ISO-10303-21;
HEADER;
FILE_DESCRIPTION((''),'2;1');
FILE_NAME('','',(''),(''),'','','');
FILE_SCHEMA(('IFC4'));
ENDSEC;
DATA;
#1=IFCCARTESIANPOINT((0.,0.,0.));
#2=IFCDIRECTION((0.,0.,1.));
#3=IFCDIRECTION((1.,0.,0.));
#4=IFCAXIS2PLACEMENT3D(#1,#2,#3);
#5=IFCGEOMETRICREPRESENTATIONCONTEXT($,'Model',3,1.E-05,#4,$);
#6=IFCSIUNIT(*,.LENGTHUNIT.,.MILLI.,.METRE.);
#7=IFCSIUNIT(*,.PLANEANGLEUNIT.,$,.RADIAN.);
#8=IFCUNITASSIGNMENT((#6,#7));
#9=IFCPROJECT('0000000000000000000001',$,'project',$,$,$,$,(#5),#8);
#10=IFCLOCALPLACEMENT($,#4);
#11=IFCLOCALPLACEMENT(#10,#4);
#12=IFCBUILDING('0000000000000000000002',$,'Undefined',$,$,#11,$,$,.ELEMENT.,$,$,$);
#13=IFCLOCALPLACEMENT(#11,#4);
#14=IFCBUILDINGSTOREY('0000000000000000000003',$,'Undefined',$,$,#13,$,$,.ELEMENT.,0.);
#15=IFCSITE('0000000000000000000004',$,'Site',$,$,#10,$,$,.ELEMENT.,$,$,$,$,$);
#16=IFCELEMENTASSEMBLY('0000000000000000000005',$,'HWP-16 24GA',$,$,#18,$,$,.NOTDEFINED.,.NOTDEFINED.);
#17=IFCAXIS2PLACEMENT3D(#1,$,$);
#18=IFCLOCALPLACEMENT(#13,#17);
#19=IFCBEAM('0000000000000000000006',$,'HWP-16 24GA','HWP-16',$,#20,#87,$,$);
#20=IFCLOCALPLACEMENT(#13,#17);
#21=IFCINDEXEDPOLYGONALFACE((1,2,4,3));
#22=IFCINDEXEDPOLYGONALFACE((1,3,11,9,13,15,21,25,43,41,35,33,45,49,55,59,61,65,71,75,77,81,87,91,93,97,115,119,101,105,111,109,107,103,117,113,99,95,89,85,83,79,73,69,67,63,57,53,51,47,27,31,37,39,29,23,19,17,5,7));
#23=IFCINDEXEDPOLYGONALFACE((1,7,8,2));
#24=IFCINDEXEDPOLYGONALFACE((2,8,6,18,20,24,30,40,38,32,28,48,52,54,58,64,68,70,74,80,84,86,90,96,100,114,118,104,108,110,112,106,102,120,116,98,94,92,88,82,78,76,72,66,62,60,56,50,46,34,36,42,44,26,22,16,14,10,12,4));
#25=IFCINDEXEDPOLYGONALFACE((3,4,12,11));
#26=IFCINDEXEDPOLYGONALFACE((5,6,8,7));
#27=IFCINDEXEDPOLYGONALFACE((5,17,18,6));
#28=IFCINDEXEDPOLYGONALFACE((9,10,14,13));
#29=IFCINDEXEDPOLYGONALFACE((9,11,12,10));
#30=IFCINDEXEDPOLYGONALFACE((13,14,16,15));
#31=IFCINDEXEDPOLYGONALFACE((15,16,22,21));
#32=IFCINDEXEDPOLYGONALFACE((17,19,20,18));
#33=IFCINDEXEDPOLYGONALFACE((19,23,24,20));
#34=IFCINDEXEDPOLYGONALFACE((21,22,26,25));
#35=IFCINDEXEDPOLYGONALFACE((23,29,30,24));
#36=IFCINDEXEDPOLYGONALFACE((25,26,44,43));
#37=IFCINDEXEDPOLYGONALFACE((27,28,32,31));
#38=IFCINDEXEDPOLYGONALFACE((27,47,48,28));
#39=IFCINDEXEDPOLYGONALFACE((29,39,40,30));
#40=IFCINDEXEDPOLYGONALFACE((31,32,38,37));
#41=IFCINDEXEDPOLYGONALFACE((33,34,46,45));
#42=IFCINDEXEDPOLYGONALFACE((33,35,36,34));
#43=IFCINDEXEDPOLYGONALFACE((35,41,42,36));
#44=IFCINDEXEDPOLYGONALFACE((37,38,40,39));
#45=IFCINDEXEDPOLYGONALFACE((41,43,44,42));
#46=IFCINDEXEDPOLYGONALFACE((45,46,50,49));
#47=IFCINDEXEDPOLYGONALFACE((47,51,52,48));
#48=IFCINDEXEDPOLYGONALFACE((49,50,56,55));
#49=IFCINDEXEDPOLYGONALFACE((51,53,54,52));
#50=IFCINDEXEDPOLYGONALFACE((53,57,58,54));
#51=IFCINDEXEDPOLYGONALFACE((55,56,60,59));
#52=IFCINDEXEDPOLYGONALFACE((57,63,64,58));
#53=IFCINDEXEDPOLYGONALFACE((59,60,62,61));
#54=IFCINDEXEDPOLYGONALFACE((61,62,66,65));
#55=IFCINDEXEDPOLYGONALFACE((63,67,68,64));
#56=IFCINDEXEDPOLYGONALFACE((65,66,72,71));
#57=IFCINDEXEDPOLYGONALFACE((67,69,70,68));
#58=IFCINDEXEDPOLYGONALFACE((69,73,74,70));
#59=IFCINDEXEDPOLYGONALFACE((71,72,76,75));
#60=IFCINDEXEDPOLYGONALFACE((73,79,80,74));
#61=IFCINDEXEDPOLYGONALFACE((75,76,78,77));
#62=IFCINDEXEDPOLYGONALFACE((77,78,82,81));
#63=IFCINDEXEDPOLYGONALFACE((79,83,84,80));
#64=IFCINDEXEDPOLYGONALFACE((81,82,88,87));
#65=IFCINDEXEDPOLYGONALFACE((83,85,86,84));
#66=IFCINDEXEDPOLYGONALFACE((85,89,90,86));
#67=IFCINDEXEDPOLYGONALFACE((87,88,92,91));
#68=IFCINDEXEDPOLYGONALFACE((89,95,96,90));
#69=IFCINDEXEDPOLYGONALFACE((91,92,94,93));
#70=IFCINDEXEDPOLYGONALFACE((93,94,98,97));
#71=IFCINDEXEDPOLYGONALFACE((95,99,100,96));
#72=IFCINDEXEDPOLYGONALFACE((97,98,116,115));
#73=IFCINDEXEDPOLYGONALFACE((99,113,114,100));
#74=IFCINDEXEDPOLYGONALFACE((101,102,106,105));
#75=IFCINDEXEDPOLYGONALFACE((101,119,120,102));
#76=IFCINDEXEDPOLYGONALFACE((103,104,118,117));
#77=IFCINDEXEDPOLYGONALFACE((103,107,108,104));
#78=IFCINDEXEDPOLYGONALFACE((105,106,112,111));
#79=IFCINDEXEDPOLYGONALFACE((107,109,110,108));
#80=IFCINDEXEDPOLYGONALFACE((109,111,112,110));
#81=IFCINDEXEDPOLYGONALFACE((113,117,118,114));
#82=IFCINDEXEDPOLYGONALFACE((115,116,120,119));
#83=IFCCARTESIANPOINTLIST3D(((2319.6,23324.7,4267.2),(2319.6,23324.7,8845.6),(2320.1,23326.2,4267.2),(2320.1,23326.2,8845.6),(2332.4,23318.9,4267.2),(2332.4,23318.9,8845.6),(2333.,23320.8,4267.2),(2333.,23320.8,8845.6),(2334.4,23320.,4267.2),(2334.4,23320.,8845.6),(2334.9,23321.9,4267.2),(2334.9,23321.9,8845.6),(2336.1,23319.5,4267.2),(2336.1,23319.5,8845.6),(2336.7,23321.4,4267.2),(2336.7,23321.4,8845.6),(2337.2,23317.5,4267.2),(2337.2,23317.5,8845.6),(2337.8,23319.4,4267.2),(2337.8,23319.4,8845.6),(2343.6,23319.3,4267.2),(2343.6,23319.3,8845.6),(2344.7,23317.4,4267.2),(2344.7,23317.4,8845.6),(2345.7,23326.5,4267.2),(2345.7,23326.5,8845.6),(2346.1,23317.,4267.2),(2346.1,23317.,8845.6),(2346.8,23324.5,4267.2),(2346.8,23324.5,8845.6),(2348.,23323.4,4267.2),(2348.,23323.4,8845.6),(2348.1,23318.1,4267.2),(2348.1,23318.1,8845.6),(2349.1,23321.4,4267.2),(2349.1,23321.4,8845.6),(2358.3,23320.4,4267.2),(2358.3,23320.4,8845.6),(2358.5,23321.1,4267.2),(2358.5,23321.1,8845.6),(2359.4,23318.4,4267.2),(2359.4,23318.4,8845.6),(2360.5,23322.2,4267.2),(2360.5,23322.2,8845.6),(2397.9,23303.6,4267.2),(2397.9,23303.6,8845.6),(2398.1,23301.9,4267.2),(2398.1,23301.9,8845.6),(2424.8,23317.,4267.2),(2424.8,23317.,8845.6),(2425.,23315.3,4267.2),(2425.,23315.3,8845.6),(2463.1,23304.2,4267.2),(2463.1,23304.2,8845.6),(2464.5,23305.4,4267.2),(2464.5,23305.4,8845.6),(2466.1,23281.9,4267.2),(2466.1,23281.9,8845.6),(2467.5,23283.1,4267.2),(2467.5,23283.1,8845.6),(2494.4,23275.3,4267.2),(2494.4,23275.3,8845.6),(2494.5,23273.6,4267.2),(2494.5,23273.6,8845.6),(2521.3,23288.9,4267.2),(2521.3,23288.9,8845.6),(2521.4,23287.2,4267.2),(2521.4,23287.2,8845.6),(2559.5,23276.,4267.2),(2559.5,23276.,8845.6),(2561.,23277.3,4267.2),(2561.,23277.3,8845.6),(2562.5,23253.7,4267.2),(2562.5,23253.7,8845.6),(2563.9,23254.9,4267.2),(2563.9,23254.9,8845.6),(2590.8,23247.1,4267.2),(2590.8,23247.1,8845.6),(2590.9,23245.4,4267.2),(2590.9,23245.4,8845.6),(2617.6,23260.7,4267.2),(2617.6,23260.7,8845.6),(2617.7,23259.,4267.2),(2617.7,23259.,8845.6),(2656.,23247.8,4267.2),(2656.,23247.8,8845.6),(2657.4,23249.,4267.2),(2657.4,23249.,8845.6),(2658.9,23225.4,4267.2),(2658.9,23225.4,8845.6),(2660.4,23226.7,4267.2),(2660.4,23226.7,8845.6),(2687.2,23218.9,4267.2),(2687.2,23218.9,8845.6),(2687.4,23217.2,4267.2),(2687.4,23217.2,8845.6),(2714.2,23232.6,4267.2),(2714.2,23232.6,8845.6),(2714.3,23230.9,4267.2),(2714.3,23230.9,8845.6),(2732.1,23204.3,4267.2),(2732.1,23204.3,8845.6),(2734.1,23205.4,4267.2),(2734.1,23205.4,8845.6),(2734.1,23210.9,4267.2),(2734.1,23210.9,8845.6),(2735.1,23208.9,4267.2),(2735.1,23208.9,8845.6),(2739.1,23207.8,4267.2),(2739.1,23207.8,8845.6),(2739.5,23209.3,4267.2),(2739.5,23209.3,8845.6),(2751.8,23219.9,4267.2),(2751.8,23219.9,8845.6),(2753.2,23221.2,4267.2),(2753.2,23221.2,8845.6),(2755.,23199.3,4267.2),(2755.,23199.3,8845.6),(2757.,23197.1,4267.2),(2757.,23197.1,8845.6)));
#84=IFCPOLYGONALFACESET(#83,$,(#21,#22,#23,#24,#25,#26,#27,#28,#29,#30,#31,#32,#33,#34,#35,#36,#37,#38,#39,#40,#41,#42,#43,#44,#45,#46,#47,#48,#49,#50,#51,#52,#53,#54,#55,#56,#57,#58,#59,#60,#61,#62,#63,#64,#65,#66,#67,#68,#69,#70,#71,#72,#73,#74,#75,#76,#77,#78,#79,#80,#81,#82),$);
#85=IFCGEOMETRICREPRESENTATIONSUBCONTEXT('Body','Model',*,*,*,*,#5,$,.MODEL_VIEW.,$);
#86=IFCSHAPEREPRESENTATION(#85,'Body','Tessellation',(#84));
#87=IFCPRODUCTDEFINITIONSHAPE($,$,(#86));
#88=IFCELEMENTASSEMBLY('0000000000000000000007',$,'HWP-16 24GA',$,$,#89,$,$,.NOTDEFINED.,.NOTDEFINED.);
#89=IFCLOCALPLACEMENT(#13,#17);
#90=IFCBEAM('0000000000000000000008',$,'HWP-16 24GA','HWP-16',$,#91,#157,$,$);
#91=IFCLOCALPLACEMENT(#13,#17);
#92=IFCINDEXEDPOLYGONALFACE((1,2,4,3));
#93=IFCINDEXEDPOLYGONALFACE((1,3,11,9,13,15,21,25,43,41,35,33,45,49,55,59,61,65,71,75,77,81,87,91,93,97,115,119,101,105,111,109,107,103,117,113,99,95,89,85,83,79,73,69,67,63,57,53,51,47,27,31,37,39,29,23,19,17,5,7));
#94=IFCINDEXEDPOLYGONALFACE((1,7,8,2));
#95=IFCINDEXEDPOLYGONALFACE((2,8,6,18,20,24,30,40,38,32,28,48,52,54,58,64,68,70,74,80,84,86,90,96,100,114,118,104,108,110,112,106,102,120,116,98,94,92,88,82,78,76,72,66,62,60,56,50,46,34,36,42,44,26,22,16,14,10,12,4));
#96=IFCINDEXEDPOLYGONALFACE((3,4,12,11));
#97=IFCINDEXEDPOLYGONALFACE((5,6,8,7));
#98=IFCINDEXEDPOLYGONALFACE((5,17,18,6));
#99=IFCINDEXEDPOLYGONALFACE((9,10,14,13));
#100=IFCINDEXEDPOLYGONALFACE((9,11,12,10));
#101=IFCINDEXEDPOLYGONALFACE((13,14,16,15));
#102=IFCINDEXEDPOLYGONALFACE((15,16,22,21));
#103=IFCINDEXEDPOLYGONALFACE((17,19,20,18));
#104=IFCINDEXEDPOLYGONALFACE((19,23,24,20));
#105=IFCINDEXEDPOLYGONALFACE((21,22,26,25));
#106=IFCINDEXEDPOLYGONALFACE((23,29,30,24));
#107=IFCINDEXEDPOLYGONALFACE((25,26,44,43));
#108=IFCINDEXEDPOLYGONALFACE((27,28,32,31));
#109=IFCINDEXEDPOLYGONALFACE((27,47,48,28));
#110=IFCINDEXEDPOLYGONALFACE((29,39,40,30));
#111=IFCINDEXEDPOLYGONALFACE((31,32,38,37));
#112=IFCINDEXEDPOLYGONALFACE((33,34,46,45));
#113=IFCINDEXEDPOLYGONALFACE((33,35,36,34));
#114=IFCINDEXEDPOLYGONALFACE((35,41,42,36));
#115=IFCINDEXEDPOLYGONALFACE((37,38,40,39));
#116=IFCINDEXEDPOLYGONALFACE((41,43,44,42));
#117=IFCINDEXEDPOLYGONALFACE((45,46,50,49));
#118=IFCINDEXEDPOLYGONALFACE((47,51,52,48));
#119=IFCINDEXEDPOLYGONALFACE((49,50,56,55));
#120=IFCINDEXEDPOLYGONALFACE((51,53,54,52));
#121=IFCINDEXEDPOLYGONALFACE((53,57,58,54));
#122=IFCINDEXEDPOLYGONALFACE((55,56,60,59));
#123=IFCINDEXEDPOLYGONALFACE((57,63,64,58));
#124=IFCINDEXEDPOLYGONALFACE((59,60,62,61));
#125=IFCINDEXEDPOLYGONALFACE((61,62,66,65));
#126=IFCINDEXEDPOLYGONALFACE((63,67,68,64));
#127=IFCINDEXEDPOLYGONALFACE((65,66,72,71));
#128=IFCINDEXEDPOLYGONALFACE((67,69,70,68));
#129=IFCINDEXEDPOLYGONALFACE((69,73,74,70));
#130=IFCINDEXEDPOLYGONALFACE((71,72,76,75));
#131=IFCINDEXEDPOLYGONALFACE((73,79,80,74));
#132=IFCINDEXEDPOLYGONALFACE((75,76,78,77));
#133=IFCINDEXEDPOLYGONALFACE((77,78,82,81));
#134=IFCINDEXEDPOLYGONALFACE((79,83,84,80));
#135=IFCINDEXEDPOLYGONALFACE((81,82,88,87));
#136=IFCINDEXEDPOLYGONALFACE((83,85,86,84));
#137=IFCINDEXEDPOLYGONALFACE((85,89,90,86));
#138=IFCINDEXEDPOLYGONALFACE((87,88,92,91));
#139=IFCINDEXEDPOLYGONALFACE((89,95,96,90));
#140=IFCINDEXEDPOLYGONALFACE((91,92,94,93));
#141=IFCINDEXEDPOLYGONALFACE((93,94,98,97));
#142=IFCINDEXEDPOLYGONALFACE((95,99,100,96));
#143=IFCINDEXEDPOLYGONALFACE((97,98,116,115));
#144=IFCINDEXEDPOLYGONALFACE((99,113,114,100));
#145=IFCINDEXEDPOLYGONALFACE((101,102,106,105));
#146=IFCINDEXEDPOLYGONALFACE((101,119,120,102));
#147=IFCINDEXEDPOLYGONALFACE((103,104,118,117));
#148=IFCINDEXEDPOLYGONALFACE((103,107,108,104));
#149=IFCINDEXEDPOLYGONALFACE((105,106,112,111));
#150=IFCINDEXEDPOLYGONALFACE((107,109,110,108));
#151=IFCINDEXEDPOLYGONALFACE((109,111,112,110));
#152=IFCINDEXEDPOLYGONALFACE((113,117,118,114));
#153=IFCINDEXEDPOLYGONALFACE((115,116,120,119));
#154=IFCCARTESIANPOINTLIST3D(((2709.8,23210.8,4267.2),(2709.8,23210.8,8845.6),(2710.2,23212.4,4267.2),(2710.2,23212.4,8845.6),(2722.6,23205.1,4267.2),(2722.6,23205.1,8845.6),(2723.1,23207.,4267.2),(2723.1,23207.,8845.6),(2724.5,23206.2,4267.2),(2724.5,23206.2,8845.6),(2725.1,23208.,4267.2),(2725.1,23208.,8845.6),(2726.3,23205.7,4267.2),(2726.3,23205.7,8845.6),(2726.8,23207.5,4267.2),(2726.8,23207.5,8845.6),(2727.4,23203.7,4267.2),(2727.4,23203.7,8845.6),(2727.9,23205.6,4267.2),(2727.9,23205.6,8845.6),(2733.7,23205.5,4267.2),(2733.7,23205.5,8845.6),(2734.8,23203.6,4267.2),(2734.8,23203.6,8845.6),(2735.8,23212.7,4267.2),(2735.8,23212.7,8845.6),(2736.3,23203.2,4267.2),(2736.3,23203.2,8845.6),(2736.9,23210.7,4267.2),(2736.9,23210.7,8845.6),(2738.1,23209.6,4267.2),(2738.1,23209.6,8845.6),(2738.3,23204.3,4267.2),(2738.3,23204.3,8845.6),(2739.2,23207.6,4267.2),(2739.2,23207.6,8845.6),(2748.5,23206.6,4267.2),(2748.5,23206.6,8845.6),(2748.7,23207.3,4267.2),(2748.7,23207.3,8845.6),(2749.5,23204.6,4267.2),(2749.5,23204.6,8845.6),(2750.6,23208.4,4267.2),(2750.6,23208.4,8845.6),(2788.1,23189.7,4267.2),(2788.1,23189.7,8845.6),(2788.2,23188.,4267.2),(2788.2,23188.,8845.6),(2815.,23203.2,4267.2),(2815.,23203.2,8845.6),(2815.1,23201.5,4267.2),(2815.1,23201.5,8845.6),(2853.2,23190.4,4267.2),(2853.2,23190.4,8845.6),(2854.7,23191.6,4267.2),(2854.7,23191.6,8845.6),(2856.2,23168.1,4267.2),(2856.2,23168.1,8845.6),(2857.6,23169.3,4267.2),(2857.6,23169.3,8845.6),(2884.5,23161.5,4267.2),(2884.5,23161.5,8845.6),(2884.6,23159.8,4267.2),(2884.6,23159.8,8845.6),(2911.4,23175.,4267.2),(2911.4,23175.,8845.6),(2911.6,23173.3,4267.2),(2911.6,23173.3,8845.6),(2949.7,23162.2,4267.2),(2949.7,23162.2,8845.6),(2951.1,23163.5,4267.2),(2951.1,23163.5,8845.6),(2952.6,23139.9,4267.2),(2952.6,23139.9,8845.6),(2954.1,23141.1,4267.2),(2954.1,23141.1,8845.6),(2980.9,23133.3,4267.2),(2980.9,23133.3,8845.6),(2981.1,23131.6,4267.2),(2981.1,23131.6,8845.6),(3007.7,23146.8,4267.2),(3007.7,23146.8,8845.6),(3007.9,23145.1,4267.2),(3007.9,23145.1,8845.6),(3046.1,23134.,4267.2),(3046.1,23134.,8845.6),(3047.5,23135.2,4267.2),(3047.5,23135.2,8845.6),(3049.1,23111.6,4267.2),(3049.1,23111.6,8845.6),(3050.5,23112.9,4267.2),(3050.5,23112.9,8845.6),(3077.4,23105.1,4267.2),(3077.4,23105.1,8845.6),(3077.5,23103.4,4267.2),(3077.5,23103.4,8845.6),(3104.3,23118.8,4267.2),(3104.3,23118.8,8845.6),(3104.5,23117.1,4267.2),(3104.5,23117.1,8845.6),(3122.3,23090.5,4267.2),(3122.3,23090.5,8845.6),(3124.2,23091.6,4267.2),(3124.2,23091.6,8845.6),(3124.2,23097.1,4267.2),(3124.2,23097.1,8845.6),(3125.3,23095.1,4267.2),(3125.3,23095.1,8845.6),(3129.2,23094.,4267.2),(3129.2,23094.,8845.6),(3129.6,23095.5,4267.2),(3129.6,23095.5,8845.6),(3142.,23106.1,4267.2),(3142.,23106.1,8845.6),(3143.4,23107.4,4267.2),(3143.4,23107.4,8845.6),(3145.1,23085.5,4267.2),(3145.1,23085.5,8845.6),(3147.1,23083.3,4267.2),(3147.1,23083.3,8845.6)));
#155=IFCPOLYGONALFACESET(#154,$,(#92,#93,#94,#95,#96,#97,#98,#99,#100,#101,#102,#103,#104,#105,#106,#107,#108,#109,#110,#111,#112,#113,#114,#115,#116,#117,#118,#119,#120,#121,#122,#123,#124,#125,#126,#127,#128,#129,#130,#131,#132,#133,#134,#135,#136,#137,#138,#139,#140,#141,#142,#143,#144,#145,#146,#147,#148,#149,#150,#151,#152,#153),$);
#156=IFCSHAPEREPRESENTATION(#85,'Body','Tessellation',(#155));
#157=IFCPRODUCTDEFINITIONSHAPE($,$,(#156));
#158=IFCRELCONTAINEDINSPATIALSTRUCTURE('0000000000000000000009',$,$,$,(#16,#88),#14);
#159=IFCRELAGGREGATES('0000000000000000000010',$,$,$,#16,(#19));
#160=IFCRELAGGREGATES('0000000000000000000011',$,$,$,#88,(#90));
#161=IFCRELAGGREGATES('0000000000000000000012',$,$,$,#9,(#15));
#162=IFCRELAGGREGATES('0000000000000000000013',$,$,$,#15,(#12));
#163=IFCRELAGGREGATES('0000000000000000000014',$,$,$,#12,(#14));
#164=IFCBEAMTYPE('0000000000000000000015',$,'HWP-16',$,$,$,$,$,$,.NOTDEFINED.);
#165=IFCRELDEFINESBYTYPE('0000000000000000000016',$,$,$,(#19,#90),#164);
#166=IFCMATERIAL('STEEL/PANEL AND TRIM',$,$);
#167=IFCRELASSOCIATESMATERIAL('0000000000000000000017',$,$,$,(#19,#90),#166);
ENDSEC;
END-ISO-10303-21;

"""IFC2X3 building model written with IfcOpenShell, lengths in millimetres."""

from ifc_helpers import new_model, si_unit, frame, origin_with_axes, place, context, subcontext, project, spatial, polyline, outline, extrude, clip, halfspace, material, type_object, element, aggregate, save


model = new_model("IFC2X3")

# Units and contexts
model_context = context("Model", 3, precision=1e-05, world=origin_with_axes())
body_context = subcontext(model_context, "Body", "Model", "MODEL_VIEW")
ifc_project = project(units=[si_unit("LENGTHUNIT", "METRE", prefix="MILLI"), si_unit("PLANEANGLEUNIT", "RADIAN")], contexts=[model_context])

# Site, building, storey
site_placement = place(None, origin_with_axes())
site = spatial("IfcSite", under=ifc_project, at=site_placement, Name="Site", CompositionType="ELEMENT")
building_placement = place(site_placement, origin_with_axes())
building = spatial("IfcBuilding", under=site, at=building_placement, Name="Undefined", CompositionType="ELEMENT")
storey_placement = place(building_placement, origin_with_axes())
storey = spatial("IfcBuildingStorey", under=building, at=storey_placement, Name="Undefined", CompositionType="ELEMENT", Elevation=0.0)

# Element assemblies, beams
assembly_1_placement = place(storey_placement, origin_with_axes())
assembly_1 = element("IfcElementAssembly", 1, at=assembly_1_placement, inside=storey, Name="HWP-16 24GA", AssemblyPlace="NOTDEFINED", PredefinedType="NOTDEFINED")
ifc_material_1 = material(Name="STEEL/PANEL AND TRIM")
beam_type_1 = type_object("IfcBeamType", Name="HWP-16", PredefinedType="NOTDEFINED")
beam_1_placement = place(assembly_1_placement, frame((2753.2, 23221.2, 8845.6), z_axis=(-0.280057, -0.959983, 0.0), x_axis=(0.0, 0.0, -1.0)))
beam_1 = element("IfcBeam", 2, at=beam_1_placement, type_object=beam_type_1, material=ifc_material_1, Name="HWP-16 24GA", Description="HWP-16", context=body_context, shape_type="Clipping", body=[
    clip(extrude(outline(polyline([(40.7, 0.0), (0.0, 0.0), (-10.3, 22.1), (15.5, 22.1), (15.5, 15.2), (9.9, 15.2), (9.9, 16.8), (13.9, 16.8), (13.9, 20.5), (-7.8, 20.5), (1.0, 1.6), (40.1, 1.6), (62.1, 22.2), (91.7, 22.3), (100.8, 1.7), (140.6, 1.7), (162.6, 22.2), (192.2, 22.2), (201.3, 1.6), (241.0, 1.6), (263.1, 22.1), (292.7, 22.1), (301.8, 1.6), (341.5, 1.6), (363.5, 22.0), (417.6, 22.0), (417.6, 15.3), (406.9, 15.3), (406.9, 14.6), (419.2, 14.6), (419.2, 22.1), (426.4, 22.1), (426.4, 24.0), (431.3, 24.0), (431.3, 22.1), (445.2, 22.1), (445.2, 20.5), (429.7, 20.5), (429.7, 22.5), (427.9, 22.5), (427.9, 20.5), (420.7, 20.5), (420.7, 13.0), (405.3, 13.0), (405.3, 16.9), (416.0, 16.9), (416.0, 20.4), (364.1, 20.4), (342.1, 0.0), (300.7, 0.0), (291.6, 20.5), (263.7, 20.5), (241.6, 0.0), (200.3, 0.0), (191.2, 20.6), (163.2, 20.6), (141.3, 0.1), (99.8, 0.1), (90.7, 20.7), (62.7, 20.6), (40.7, 0.0)])), frame((10000.0, 0.0, 0.0), z_axis=(-1.0, 0.0, 0.0), x_axis=(0.0, -1.0, 0.0)), (0.0, 0.0, 1.0), 10000.0), halfspace(frame((4578.4, -500.0, -500.0), z_axis=(1.0, 0.0, 0.0), x_axis=(0.0, 0.0, 1.0)), False)),
])
aggregate(assembly_1, [beam_1])
assembly_2_placement = place(storey_placement, origin_with_axes())
assembly_2 = element("IfcElementAssembly", 3, at=assembly_2_placement, inside=storey, Name="HWP-16 24GA", AssemblyPlace="NOTDEFINED", PredefinedType="NOTDEFINED")
beam_2_placement = place(assembly_2_placement, frame((3143.4, 23107.4, 8845.6), z_axis=(-0.280057, -0.959983, 0.0), x_axis=(0.0, 0.0, -1.0)))
beam_2 = element("IfcBeam", 4, at=beam_2_placement, type_object=beam_type_1, material=ifc_material_1, Name="HWP-16 24GA", Description="HWP-16", context=body_context, shape_type="Clipping", body=[
    clip(extrude(outline(polyline([(40.7, 0.0), (0.0, 0.0), (-10.3, 22.1), (15.5, 22.1), (15.5, 15.2), (9.9, 15.2), (9.9, 16.8), (13.9, 16.8), (13.9, 20.5), (-7.8, 20.5), (1.0, 1.6), (40.1, 1.6), (62.1, 22.2), (91.7, 22.3), (100.8, 1.7), (140.6, 1.7), (162.6, 22.2), (192.2, 22.2), (201.3, 1.6), (241.0, 1.6), (263.1, 22.1), (292.7, 22.1), (301.8, 1.6), (341.5, 1.6), (363.5, 22.0), (417.6, 22.0), (417.6, 15.3), (406.9, 15.3), (406.9, 14.6), (419.2, 14.6), (419.2, 22.1), (426.4, 22.1), (426.4, 24.0), (431.3, 24.0), (431.3, 22.1), (445.2, 22.1), (445.2, 20.5), (429.7, 20.5), (429.7, 22.5), (427.9, 22.5), (427.9, 20.5), (420.7, 20.5), (420.7, 13.0), (405.3, 13.0), (405.3, 16.9), (416.0, 16.9), (416.0, 20.4), (364.1, 20.4), (342.1, 0.0), (300.7, 0.0), (291.6, 20.5), (263.7, 20.5), (241.6, 0.0), (200.3, 0.0), (191.2, 20.6), (163.2, 20.6), (141.3, 0.1), (99.8, 0.1), (90.7, 20.7), (62.7, 20.6), (40.7, 0.0)])), frame((10000.0, 0.0, 0.0), z_axis=(-1.0, 0.0, 0.0), x_axis=(0.0, -1.0, 0.0)), (0.0, 0.0, 1.0), 10000.0), halfspace(frame((4578.4, -500.0, -500.0), z_axis=(1.0, 0.0, 0.0), x_axis=(0.0, 0.0, 1.0)), False)),
])
aggregate(assembly_2, [beam_2])

save(model, "model.ifc")
